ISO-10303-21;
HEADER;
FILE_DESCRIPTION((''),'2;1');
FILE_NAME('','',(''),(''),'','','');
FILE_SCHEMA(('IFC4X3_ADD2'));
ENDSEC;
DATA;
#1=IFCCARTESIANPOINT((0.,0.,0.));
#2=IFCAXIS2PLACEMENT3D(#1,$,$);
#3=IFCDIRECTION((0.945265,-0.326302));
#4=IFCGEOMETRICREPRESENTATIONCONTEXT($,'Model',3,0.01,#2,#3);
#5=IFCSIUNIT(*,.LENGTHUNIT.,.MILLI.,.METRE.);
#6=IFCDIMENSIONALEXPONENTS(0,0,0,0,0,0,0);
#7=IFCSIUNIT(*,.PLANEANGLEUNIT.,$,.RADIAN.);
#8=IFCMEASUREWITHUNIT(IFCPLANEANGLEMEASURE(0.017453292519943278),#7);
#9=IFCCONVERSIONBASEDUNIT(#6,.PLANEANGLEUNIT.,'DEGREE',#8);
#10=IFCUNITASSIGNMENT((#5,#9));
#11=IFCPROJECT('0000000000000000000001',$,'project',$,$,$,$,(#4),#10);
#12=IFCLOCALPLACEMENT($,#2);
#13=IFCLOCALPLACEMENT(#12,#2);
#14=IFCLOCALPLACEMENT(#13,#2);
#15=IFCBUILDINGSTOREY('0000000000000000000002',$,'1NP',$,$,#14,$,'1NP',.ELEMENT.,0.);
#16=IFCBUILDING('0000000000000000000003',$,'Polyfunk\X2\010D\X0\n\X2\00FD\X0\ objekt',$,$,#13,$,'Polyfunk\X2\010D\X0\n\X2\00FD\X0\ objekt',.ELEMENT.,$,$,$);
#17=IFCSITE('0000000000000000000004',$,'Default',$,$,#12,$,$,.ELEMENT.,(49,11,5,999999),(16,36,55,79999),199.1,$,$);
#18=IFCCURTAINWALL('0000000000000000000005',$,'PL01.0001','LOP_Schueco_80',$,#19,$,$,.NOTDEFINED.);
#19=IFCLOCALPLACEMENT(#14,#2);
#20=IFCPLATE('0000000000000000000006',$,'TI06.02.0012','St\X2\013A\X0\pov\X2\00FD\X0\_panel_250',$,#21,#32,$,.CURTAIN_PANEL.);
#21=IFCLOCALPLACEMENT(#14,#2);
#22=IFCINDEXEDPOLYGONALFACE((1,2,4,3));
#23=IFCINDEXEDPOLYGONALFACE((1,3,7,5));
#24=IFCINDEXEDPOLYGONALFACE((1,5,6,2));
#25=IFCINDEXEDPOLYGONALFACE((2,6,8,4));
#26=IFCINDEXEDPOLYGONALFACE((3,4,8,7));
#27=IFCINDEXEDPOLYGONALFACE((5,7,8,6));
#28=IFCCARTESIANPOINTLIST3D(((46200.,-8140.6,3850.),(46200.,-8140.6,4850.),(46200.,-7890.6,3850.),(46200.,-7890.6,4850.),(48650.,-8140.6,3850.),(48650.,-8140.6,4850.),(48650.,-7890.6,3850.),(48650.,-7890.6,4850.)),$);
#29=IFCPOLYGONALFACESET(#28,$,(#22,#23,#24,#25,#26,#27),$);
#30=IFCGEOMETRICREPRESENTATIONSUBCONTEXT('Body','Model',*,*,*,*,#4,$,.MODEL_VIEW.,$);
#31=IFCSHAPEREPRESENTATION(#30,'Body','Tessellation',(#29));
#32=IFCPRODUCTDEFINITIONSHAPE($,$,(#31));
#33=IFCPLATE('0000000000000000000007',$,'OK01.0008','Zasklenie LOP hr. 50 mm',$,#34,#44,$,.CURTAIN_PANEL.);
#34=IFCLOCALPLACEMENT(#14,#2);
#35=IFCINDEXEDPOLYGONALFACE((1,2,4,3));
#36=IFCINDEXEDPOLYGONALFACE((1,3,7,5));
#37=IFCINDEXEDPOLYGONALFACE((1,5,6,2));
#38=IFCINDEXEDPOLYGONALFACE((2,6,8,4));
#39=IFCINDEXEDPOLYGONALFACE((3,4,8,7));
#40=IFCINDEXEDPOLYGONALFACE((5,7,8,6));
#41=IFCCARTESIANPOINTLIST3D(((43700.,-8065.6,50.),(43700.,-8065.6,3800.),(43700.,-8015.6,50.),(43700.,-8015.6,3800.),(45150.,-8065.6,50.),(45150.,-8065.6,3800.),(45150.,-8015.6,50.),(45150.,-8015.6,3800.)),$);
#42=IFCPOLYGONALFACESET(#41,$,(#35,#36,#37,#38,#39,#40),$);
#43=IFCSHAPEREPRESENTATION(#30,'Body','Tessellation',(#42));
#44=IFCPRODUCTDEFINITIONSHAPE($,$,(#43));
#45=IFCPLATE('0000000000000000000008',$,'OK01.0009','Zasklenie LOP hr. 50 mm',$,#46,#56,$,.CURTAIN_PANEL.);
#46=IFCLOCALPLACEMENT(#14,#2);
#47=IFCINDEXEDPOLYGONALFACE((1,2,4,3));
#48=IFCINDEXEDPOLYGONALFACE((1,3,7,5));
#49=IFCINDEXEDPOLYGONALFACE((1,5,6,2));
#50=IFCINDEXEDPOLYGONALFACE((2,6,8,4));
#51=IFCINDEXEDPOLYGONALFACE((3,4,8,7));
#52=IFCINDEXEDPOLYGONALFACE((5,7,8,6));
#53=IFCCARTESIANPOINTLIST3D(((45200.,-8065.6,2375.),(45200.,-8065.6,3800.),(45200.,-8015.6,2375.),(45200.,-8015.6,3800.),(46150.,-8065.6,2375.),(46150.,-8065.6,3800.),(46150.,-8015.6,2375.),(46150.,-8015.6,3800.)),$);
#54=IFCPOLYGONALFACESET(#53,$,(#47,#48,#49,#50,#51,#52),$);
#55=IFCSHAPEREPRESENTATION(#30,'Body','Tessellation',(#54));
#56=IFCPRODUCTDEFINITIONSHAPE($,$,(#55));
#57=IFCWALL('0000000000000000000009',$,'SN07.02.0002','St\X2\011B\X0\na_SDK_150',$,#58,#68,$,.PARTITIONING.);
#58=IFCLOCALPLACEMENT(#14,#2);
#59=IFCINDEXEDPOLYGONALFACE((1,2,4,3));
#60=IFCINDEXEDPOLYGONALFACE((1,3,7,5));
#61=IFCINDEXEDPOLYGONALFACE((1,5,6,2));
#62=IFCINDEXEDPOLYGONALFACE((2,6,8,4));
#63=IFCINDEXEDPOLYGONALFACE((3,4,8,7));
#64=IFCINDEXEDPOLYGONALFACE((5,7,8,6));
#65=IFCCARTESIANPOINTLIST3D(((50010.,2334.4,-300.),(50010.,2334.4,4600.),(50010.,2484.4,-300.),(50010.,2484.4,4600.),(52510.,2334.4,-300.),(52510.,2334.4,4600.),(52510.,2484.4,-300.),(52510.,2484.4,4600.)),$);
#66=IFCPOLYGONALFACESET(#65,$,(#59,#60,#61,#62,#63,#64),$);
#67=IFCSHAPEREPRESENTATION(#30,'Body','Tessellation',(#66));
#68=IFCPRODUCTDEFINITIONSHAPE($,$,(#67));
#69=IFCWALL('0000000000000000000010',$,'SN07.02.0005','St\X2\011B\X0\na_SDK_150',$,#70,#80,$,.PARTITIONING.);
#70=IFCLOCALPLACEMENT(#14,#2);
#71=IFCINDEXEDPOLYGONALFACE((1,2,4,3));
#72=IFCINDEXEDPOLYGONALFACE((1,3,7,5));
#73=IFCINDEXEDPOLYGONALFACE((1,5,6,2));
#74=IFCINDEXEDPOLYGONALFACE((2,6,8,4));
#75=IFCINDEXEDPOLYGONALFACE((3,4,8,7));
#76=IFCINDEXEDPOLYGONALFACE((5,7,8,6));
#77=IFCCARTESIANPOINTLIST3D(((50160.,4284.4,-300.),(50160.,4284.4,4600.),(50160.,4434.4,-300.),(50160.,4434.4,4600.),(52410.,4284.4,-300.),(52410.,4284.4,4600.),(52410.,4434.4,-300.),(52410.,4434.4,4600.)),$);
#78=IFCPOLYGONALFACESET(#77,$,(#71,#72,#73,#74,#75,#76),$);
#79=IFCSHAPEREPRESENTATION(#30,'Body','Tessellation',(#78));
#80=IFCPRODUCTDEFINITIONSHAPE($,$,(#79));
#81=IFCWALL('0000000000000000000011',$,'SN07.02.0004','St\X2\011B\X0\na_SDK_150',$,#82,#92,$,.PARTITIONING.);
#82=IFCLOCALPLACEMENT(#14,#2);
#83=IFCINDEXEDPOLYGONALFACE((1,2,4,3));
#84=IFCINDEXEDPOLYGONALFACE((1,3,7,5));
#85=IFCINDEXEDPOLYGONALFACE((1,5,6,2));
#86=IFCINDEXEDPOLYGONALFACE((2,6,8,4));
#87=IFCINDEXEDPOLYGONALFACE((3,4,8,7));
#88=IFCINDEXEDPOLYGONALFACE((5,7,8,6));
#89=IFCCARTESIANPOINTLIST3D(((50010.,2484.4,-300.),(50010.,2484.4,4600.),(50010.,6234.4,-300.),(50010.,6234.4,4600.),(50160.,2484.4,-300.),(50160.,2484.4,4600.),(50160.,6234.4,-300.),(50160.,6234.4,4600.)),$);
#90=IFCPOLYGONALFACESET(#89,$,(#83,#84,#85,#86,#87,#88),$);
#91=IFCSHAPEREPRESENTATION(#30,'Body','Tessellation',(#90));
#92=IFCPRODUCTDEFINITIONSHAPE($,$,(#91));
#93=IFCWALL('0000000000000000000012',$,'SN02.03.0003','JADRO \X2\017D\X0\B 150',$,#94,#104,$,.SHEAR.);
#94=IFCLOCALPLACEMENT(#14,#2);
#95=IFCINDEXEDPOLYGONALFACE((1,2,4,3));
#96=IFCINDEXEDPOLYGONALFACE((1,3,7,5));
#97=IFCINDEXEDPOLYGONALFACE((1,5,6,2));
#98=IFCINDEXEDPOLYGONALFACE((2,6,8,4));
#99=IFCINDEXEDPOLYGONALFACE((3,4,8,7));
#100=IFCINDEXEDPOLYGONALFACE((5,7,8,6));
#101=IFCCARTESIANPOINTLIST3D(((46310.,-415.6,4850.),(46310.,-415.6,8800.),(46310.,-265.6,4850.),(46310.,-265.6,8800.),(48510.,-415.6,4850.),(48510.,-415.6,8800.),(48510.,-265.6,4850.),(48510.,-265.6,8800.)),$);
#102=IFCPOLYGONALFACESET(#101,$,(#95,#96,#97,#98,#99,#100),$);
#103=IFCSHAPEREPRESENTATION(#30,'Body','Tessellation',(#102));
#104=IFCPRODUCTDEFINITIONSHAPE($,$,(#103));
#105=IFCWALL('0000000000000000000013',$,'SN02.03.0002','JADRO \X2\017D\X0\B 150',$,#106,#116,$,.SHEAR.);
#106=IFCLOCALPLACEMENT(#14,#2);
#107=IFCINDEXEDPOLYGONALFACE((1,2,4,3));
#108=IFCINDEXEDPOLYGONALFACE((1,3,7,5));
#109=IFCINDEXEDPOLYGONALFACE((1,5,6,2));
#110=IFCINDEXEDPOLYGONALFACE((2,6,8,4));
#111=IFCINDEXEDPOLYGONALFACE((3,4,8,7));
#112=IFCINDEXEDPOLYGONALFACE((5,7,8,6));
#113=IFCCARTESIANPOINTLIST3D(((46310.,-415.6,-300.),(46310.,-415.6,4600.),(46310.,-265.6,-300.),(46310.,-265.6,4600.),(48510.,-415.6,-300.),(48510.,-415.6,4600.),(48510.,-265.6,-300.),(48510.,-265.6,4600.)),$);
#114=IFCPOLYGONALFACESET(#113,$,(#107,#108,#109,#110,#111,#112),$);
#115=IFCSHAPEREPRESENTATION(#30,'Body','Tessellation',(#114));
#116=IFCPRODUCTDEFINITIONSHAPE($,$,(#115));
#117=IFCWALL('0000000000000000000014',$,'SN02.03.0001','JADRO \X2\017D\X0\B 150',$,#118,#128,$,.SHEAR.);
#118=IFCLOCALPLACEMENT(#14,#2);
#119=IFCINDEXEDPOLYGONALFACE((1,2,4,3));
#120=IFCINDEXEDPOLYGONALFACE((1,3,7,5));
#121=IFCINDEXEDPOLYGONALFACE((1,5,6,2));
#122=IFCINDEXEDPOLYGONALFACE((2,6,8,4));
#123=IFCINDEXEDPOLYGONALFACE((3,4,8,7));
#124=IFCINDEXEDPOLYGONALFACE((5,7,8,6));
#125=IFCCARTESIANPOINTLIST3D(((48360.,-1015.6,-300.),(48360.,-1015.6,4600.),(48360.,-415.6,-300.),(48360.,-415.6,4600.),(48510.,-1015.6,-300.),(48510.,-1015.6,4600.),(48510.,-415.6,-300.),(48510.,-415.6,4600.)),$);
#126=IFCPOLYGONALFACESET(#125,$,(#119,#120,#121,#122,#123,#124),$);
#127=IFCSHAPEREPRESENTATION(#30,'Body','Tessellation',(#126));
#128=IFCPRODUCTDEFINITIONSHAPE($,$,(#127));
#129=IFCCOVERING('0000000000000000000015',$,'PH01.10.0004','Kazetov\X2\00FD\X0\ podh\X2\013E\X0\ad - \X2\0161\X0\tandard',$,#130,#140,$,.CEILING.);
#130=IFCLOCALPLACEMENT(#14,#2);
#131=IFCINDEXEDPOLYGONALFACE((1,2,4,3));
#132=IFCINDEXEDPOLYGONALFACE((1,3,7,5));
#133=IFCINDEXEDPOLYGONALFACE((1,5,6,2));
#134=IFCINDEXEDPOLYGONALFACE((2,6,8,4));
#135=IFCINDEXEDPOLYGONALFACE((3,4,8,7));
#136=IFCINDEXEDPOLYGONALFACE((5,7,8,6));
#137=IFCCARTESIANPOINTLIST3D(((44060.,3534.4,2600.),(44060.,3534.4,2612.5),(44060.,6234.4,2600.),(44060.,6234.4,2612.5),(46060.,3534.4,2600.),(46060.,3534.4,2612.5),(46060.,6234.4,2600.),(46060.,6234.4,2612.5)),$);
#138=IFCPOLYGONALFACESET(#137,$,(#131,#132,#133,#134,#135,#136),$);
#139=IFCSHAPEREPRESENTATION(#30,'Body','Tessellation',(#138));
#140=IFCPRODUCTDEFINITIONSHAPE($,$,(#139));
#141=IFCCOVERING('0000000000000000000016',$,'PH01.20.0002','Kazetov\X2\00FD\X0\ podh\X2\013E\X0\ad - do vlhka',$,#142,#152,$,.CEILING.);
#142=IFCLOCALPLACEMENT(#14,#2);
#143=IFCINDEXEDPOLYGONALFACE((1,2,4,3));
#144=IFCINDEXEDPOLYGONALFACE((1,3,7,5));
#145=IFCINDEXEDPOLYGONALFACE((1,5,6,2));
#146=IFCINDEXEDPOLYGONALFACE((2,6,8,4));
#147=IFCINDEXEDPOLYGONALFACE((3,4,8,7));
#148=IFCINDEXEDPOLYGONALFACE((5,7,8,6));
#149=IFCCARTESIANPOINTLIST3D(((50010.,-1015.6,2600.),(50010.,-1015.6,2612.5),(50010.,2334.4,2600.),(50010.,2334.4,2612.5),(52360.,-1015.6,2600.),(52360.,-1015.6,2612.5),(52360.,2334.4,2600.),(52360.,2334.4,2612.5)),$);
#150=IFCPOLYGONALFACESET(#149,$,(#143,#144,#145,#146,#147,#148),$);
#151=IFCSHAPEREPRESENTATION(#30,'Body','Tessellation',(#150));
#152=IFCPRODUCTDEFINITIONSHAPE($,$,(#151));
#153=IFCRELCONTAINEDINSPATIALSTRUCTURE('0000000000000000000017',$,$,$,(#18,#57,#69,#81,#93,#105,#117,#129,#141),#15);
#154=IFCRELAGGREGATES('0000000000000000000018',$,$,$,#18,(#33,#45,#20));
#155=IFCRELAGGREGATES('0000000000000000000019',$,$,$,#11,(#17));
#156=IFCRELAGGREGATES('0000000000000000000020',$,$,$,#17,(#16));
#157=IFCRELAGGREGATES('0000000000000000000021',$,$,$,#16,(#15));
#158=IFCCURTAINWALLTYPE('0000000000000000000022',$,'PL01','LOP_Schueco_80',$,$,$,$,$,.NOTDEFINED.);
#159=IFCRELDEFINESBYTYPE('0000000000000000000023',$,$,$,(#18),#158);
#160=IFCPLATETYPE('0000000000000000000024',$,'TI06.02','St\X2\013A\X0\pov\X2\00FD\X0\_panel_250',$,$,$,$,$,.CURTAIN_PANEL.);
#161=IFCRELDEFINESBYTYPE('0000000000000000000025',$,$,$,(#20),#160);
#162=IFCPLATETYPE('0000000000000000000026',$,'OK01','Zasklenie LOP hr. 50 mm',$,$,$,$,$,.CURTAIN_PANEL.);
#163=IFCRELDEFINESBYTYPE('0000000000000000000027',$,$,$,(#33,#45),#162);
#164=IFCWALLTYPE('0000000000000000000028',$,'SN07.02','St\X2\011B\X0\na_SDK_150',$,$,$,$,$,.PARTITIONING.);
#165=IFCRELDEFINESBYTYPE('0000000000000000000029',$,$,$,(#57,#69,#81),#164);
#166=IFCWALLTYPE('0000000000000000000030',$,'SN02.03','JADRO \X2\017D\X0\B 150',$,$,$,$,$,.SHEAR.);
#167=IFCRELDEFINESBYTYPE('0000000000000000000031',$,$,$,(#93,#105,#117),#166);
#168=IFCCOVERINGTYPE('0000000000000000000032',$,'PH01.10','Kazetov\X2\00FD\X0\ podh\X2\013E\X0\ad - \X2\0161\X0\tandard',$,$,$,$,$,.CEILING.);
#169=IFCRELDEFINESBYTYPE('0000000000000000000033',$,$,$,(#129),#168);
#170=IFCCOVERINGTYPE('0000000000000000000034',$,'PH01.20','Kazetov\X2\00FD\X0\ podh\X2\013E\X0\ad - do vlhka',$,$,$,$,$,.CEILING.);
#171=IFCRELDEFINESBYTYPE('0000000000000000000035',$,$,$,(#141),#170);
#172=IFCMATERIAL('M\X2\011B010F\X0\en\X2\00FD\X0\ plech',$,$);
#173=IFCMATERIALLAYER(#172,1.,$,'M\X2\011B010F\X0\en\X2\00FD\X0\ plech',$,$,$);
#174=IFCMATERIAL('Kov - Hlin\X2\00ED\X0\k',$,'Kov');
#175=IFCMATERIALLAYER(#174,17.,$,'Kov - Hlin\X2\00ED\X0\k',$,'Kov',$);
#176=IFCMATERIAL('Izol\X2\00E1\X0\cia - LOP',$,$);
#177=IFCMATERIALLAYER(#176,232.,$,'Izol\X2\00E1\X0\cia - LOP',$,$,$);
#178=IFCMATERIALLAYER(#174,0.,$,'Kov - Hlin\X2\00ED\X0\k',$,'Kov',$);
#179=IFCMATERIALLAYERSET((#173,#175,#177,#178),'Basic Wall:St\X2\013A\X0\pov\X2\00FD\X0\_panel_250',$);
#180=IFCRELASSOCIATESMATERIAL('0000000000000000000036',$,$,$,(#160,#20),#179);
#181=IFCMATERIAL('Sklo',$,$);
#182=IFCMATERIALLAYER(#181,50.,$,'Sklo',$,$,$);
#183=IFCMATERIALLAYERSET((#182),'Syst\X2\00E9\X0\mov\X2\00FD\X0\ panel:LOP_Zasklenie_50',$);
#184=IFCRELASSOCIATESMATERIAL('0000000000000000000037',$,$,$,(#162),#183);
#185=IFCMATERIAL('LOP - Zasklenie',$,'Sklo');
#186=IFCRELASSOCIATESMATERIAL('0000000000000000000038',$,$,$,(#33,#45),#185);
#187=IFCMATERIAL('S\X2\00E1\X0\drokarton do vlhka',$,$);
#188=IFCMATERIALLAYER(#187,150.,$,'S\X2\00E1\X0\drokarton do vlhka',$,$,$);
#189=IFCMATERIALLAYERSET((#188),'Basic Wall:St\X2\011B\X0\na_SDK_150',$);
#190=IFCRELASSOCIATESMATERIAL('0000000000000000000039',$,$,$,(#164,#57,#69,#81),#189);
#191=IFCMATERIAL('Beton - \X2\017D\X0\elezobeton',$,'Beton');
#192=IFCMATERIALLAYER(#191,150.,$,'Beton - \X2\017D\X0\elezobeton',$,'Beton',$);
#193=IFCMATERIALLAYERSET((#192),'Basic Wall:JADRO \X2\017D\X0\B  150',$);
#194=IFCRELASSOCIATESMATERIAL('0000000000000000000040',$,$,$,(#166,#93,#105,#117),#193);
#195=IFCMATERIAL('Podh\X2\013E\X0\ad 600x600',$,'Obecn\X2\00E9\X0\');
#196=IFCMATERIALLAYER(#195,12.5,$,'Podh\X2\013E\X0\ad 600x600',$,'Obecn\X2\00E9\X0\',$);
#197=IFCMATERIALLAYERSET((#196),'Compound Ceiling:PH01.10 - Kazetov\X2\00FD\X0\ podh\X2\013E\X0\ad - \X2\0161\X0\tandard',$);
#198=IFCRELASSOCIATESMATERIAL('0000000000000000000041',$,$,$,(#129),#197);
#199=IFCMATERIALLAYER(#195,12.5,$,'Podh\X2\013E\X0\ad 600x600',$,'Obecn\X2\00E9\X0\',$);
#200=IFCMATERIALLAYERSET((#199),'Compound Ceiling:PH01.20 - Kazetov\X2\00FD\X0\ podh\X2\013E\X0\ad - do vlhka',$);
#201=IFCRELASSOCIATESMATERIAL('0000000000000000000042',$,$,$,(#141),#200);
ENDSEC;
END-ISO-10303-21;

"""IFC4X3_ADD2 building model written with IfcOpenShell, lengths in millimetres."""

from ifc_helpers import new_model, entity, si_unit, converted_unit, direction, frame, frame_2d, origin, origin_2d_with_axis, place, context, subcontext, project, spatial, polyline, rectangle, extrude, clip, bounded_halfspace, source, transform, mapped, material, layer, layer_set, layer_usage, type_object, type_shapes, element, aggregate, save


model = new_model("IFC4X3_ADD2")

# Units and contexts
model_context = context("Model", 3, precision=0.01, world=origin(), true_north=direction((0.945265, -0.326302)))
body_context = subcontext(model_context, "Body", "Model", "MODEL_VIEW")
ifc_project = project(units=[si_unit("LENGTHUNIT", "METRE", prefix="MILLI"), converted_unit("PLANEANGLEUNIT", "DEGREE", entity("IfcPlaneAngleMeasure", 0.017453292519943278), si_unit("PLANEANGLEUNIT", "RADIAN"), dimensions=[0, 0, 0, 0, 0, 0, 0])], contexts=[model_context])

# Site, building, storey
site_placement = place(None, origin())
site = spatial("IfcSite", under=ifc_project, at=site_placement, Name="Default", CompositionType="ELEMENT", RefLatitude=(49, 11, 5, 999999), RefLongitude=(16, 36, 55, 79999), RefElevation=199.1)
building_placement = place(site_placement, origin())
building = spatial("IfcBuilding", under=site, at=building_placement, Name="Polyfunkčný objekt", LongName="Polyfunkčný objekt", CompositionType="ELEMENT")
storey_placement = place(building_placement, origin())
storey = spatial("IfcBuildingStorey", under=building, at=storey_placement, Name="1NP", LongName="1NP", CompositionType="ELEMENT", Elevation=0.0)

# Curtain wall, plates
curtain_wall_type = type_object("IfcCurtainWallType", Name="PL01", Description="LOP_Schueco_80", PredefinedType="NOTDEFINED")
curtain_wall_placement = place(storey_placement, origin())
curtain_wall = element("IfcCurtainWall", 1, at=curtain_wall_placement, inside=storey, type_object=curtain_wall_type, Name="PL01.0001", Description="LOP_Schueco_80", PredefinedType="NOTDEFINED")
ifc_material_1 = material(Name="Měďený plech")
ifc_layer_1 = layer(ifc_material_1, 1.0, Name="Měďený plech")
ifc_material_2 = material(Name="Kov - Hliník", Category="Kov")
ifc_layer_2 = layer(ifc_material_2, 17.0, Name="Kov - Hliník", Category="Kov")
ifc_material_3 = material(Name="Izolácia - LOP")
ifc_layer_3 = layer(ifc_material_3, 232.0, Name="Izolácia - LOP")
ifc_layer_4 = layer(ifc_material_2, 0.0, Name="Kov - Hliník", Category="Kov")
ifc_layer_set_1 = layer_set([ifc_layer_1, ifc_layer_2, ifc_layer_3, ifc_layer_4], Name="Basic Wall:Stĺpový_panel_250")
ifc_layer_usage_1 = layer_usage(ifc_layer_set_1, "AXIS2", "POSITIVE", -125.0)
plate_type_1 = type_object("IfcPlateType", Name="TI06.02", Description="Stĺpový_panel_250", PredefinedType="CURTAIN_PANEL", material=ifc_layer_set_1)
plate_1_placement = place(storey_placement, frame((46200.0, -8015.6, 3850.0)))
plate_1 = element("IfcPlate", 2, at=plate_1_placement, type_object=plate_type_1, material=ifc_layer_usage_1, Name="TI06.02.0012", Description="Stĺpový_panel_250", PredefinedType="CURTAIN_PANEL", context=body_context, shape_type="SweptSolid", body=[
    extrude(rectangle(XDim=250.0, YDim=2450.0, at=origin_2d_with_axis()), frame((1225.0, 0.0, 0.0), z_axis=(0.0, 0.0, 1.0), x_axis=(0.0, 1.0, 0.0)), (0.0, 0.0, 1.0), 1000.0),
])
ifc_material_4 = material(Name="LOP - Zasklenie", Category="Sklo")
ifc_material_5 = material(Name="Sklo")
ifc_layer_5 = layer(ifc_material_5, 50.0, Name="Sklo")
ifc_layer_set_2 = layer_set([ifc_layer_5], Name="Systémový panel:LOP_Zasklenie_50")
plate_type_2 = type_object("IfcPlateType", Name="OK01", Description="Zasklenie LOP hr. 50 mm", PredefinedType="CURTAIN_PANEL", material=ifc_layer_set_2)
shared_shape_1 = source(origin(), body_context, "Body", "SweptSolid", [
    extrude(rectangle(XDim=3750.0, YDim=1450.0, at=frame_2d((-331.2, 0.0), x_axis=(1.0, 0.0))), frame((0.0, -50.0, 2206.2), z_axis=(0.0, 1.0, 0.0), x_axis=(0.0, 0.0, 1.0)), (0.0, 0.0, 1.0), 50.0),
])
plate_2_placement = place(curtain_wall_placement, frame((44425.0, -8015.6, 50.0)))
plate_2 = element("IfcPlate", 3, at=plate_2_placement, type_object=plate_type_2, material=ifc_material_4, Name="OK01.0008", Description="Zasklenie LOP hr. 50 mm", PredefinedType="CURTAIN_PANEL", context=body_context, shape_type="MappedRepresentation", body=[
    mapped(shared_shape_1, transform((0.0, 0.0, 0.0), scale=1.0)),
])
shared_shape_2 = source(origin(), body_context, "Body", "SweptSolid", [
    extrude(rectangle(XDim=1425.0, YDim=950.0, at=frame_2d((87.6, 0.0), x_axis=(1.0, 0.0))), frame((0.0, -50.0, 624.9), z_axis=(0.0, 1.0, 0.0), x_axis=(0.0, 0.0, 1.0)), (0.0, 0.0, 1.0), 50.0),
])
type_shapes(plate_type_2, [shared_shape_1, shared_shape_2])
plate_3_placement = place(curtain_wall_placement, frame((45675.0, -8015.6, 2375.0)))
plate_3 = element("IfcPlate", 4, at=plate_3_placement, type_object=plate_type_2, material=ifc_material_4, Name="OK01.0009", Description="Zasklenie LOP hr. 50 mm", PredefinedType="CURTAIN_PANEL", context=body_context, shape_type="MappedRepresentation", body=[
    mapped(shared_shape_2, transform((0.0, 0.0, 0.0), scale=1.0)),
])
aggregate(curtain_wall, [plate_2, plate_3, plate_1])

# Walls
ifc_material_6 = material(Name="Sádrokarton do vlhka")
ifc_layer_6 = layer(ifc_material_6, 150.0, Name="Sádrokarton do vlhka")
ifc_layer_set_3 = layer_set([ifc_layer_6], Name="Basic Wall:Stěna_SDK_150")
wall_type_1 = type_object("IfcWallType", Name="SN07.02", Description="Stěna_SDK_150", PredefinedType="PARTITIONING", material=ifc_layer_set_3)
wall_1_placement = place(storey_placement, frame((50010.0, 2409.4, -300.0)))
element("IfcWall", 5, at=wall_1_placement, inside=storey, type_object=wall_type_1, material=ifc_layer_set_3, Name="SN07.02.0002", Description="Stěna_SDK_150", PredefinedType="PARTITIONING", context=body_context, shape_type="Clipping", body=[
    clip(clip(extrude(rectangle(XDim=2500.0, YDim=150.0, at=frame_2d((1250.0, 0.0), x_axis=(-1.0, 0.0))), origin(), (0.0, 0.0, 1.0), 4900.0), bounded_halfspace(frame((2500.0, -75.0, 0.0), z_axis=(0.0, 0.0, 1.0), x_axis=(0.0, 1.0, 0.0)), True, frame((2500.0, -75.0, 0.0)), polyline([(0.0, 0.0), (0.0, 150.0), (-100.0, 150.0), (-2350.0, 150.0), (-2500.0, 150.0), (-2500.0, 0.0), (-150.0, 0.0), (0.0, 0.0)]))), bounded_halfspace(frame((0.0, -75.0, 4900.0), z_axis=(0.0, 0.0, -1.0), x_axis=(1.0, 0.0, 0.0)), True, frame((0.0, -75.0, 4900.0)), polyline([(0.0, 0.0), (2350.0, 0.0), (2500.0, 0.0), (2500.0, 150.0), (2400.0, 150.0), (150.0, 150.0), (0.0, 150.0), (0.0, 0.0)]))),
])
wall_2_placement = place(storey_placement, frame((50160.0, 4359.4, -300.0)))
element("IfcWall", 6, at=wall_2_placement, inside=storey, type_object=wall_type_1, material=ifc_layer_set_3, Name="SN07.02.0005", Description="Stěna_SDK_150", PredefinedType="PARTITIONING", context=body_context, shape_type="Clipping", body=[
    clip(clip(extrude(rectangle(XDim=2250.0, YDim=150.0, at=frame_2d((1125.0, 0.0), x_axis=(-1.0, 0.0))), origin(), (0.0, 0.0, 1.0), 4900.0), bounded_halfspace(frame((2250.0, -75.0, 0.0), z_axis=(0.0, 0.0, 1.0), x_axis=(0.0, 1.0, 0.0)), True, frame((2250.0, -75.0, 0.0)), polyline([(0.0, 0.0), (0.0, 150.0), (-2250.0, 150.0), (-2250.0, 0.0), (0.0, 0.0)]))), bounded_halfspace(frame((0.0, -75.0, 4900.0), z_axis=(0.0, 0.0, -1.0), x_axis=(1.0, 0.0, 0.0)), True, frame((0.0, -75.0, 4900.0)), polyline([(0.0, 0.0), (2250.0, 0.0), (2250.0, 150.0), (0.0, 150.0), (0.0, 0.0)]))),
])
wall_3_placement = place(storey_placement, frame((50085.0, 2484.4, -300.0), z_axis=(0.0, 0.0, 1.0), x_axis=(0.0, 1.0, 0.0)))
element("IfcWall", 7, at=wall_3_placement, inside=storey, type_object=wall_type_1, material=ifc_layer_set_3, Name="SN07.02.0004", Description="Stěna_SDK_150", PredefinedType="PARTITIONING", context=body_context, shape_type="Clipping", body=[
    clip(clip(extrude(rectangle(XDim=3750.0, YDim=150.0, at=frame_2d((1875.0, 0.0), x_axis=(-1.0, 0.0))), origin(), (0.0, 0.0, 1.0), 4900.0), bounded_halfspace(frame((0.0, -75.0, 4900.0), z_axis=(0.0, 0.0, -1.0), x_axis=(0.0, -1.0, 0.0)), True, frame((0.0, -75.0, 4900.0)), polyline([(0.0, 0.0), (1800.0, 0.0), (1950.0, 0.0), (3750.0, 0.0), (3750.0, 150.0), (0.0, 150.0), (0.0, 0.0)]))), bounded_halfspace(frame((3750.0, -75.0, 0.0)), True, frame((3750.0, -75.0, 0.0)), polyline([(0.0, 0.0), (0.0, 150.0), (-3750.0, 150.0), (-3750.0, 0.0), (-1950.0, 0.0), (-1800.0, 0.0), (0.0, 0.0)]))),
])
ifc_material_7 = material(Name="Beton - Železobeton", Category="Beton")
ifc_layer_7 = layer(ifc_material_7, 150.0, Name="Beton - Železobeton", Category="Beton")
ifc_layer_set_4 = layer_set([ifc_layer_7], Name="Basic Wall:JADRO ŽB  150")
wall_type_2 = type_object("IfcWallType", Name="SN02.03", Description="JADRO ŽB 150", PredefinedType="SHEAR", material=ifc_layer_set_4)
wall_4_placement = place(storey_placement, frame((46310.0, -340.6, 4850.0)))
element("IfcWall", 8, at=wall_4_placement, inside=storey, type_object=wall_type_2, material=ifc_layer_set_4, Name="SN02.03.0003", Description="JADRO ŽB 150", PredefinedType="SHEAR", context=body_context, shape_type="Clipping", body=[
    clip(clip(extrude(rectangle(XDim=2200.0, YDim=150.0, at=frame_2d((1100.0, 0.0), x_axis=(-1.0, 0.0))), origin(), (0.0, 0.0, 1.0), 3950.0), bounded_halfspace(frame((2200.0, -75.0, 0.0), z_axis=(0.0, 0.0, 1.0), x_axis=(-1.0, 0.0, 0.0)), True, frame((2200.0, -75.0, 0.0)), polyline([(0.0, 0.0), (0.0, 150.0), (-2200.0, 150.0), (-2200.0, 0.0), (0.0, 0.0)]))), bounded_halfspace(frame((0.0, -75.0, 3950.0), z_axis=(0.0, 0.0, -1.0), x_axis=(1.0, 0.0, 0.0)), True, frame((0.0, -75.0, 3950.0)), polyline([(0.0, 0.0), (2050.0, 0.0), (2200.0, 0.0), (2200.0, 150.0), (0.0, 150.0), (0.0, 0.0)]))),
])
wall_5_placement = place(storey_placement, frame((46310.0, -340.6, -300.0)))
element("IfcWall", 9, at=wall_5_placement, inside=storey, type_object=wall_type_2, material=ifc_layer_set_4, Name="SN02.03.0002", Description="JADRO ŽB 150", PredefinedType="SHEAR", context=body_context, shape_type="SweptSolid", body=[
    extrude(rectangle(XDim=2200.0, YDim=150.0, at=frame_2d((1100.0, 0.0), x_axis=(-1.0, 0.0))), origin(), (0.0, 0.0, 1.0), 4900.0),
])
wall_6_placement = place(storey_placement, frame((48435.0, -1015.6, -300.0), z_axis=(0.0, 0.0, 1.0), x_axis=(0.0, 1.0, 0.0)))
element("IfcWall", 10, at=wall_6_placement, inside=storey, type_object=wall_type_2, material=ifc_layer_set_4, Name="SN02.03.0001", Description="JADRO ŽB 150", PredefinedType="SHEAR", context=body_context, shape_type="SweptSolid", body=[
    extrude(rectangle(XDim=600.0, YDim=150.0, at=frame_2d((300.0, 0.0), x_axis=(-1.0, 0.0))), origin(), (0.0, 0.0, 1.0), 4900.0),
])

# Coverings
ifc_material_8 = material(Name="Podhľad 600x600", Category="Obecné")
ifc_layer_8 = layer(ifc_material_8, 12.5, Name="Podhľad 600x600", Category="Obecné")
ifc_layer_set_5 = layer_set([ifc_layer_8], Name="Compound Ceiling:PH01.10 - Kazetový podhľad - štandard")
ifc_layer_usage_2 = layer_usage(ifc_layer_set_5, "AXIS3", "NEGATIVE", 0.0)
covering_type_1 = type_object("IfcCoveringType", Name="PH01.10", Description="Kazetový podhľad - štandard", PredefinedType="CEILING")
covering_1_placement = place(storey_placement, frame((44060.0, 3534.4, 2600.0)))
element("IfcCovering", 11, at=covering_1_placement, inside=storey, type_object=covering_type_1, material=ifc_layer_usage_2, Name="PH01.10.0004", Description="Kazetový podhľad - štandard", PredefinedType="CEILING", context=body_context, shape_type="SweptSolid", body=[
    extrude(rectangle(XDim=2000.0, YDim=2700.0, at=frame_2d((0.0, 0.0), x_axis=(1.0, 0.0))), frame((1000.0, 1350.0, 0.0)), (0.0, 0.0, 1.0), 12.5),
])
ifc_layer_9 = layer(ifc_material_8, 12.5, Name="Podhľad 600x600", Category="Obecné")
ifc_layer_set_6 = layer_set([ifc_layer_9], Name="Compound Ceiling:PH01.20 - Kazetový podhľad - do vlhka")
ifc_layer_usage_3 = layer_usage(ifc_layer_set_6, "AXIS3", "NEGATIVE", 12.5)
covering_type_2 = type_object("IfcCoveringType", Name="PH01.20", Description="Kazetový podhľad - do vlhka", PredefinedType="CEILING")
covering_2_placement = place(storey_placement, frame((50010.0, -1015.6, 2600.0)))
element("IfcCovering", 12, at=covering_2_placement, inside=storey, type_object=covering_type_2, material=ifc_layer_usage_3, Name="PH01.20.0002", Description="Kazetový podhľad - do vlhka", PredefinedType="CEILING", context=body_context, shape_type="SweptSolid", body=[
    extrude(rectangle(XDim=3350.0, YDim=2350.0, at=frame_2d((0.0, 0.0), x_axis=(1.0, 0.0))), frame((1175.0, 1675.0, 0.0), z_axis=(0.0, 0.0, 1.0), x_axis=(0.0, 1.0, 0.0)), (0.0, 0.0, 1.0), 12.5),
])

save(model, "model.ifc")
